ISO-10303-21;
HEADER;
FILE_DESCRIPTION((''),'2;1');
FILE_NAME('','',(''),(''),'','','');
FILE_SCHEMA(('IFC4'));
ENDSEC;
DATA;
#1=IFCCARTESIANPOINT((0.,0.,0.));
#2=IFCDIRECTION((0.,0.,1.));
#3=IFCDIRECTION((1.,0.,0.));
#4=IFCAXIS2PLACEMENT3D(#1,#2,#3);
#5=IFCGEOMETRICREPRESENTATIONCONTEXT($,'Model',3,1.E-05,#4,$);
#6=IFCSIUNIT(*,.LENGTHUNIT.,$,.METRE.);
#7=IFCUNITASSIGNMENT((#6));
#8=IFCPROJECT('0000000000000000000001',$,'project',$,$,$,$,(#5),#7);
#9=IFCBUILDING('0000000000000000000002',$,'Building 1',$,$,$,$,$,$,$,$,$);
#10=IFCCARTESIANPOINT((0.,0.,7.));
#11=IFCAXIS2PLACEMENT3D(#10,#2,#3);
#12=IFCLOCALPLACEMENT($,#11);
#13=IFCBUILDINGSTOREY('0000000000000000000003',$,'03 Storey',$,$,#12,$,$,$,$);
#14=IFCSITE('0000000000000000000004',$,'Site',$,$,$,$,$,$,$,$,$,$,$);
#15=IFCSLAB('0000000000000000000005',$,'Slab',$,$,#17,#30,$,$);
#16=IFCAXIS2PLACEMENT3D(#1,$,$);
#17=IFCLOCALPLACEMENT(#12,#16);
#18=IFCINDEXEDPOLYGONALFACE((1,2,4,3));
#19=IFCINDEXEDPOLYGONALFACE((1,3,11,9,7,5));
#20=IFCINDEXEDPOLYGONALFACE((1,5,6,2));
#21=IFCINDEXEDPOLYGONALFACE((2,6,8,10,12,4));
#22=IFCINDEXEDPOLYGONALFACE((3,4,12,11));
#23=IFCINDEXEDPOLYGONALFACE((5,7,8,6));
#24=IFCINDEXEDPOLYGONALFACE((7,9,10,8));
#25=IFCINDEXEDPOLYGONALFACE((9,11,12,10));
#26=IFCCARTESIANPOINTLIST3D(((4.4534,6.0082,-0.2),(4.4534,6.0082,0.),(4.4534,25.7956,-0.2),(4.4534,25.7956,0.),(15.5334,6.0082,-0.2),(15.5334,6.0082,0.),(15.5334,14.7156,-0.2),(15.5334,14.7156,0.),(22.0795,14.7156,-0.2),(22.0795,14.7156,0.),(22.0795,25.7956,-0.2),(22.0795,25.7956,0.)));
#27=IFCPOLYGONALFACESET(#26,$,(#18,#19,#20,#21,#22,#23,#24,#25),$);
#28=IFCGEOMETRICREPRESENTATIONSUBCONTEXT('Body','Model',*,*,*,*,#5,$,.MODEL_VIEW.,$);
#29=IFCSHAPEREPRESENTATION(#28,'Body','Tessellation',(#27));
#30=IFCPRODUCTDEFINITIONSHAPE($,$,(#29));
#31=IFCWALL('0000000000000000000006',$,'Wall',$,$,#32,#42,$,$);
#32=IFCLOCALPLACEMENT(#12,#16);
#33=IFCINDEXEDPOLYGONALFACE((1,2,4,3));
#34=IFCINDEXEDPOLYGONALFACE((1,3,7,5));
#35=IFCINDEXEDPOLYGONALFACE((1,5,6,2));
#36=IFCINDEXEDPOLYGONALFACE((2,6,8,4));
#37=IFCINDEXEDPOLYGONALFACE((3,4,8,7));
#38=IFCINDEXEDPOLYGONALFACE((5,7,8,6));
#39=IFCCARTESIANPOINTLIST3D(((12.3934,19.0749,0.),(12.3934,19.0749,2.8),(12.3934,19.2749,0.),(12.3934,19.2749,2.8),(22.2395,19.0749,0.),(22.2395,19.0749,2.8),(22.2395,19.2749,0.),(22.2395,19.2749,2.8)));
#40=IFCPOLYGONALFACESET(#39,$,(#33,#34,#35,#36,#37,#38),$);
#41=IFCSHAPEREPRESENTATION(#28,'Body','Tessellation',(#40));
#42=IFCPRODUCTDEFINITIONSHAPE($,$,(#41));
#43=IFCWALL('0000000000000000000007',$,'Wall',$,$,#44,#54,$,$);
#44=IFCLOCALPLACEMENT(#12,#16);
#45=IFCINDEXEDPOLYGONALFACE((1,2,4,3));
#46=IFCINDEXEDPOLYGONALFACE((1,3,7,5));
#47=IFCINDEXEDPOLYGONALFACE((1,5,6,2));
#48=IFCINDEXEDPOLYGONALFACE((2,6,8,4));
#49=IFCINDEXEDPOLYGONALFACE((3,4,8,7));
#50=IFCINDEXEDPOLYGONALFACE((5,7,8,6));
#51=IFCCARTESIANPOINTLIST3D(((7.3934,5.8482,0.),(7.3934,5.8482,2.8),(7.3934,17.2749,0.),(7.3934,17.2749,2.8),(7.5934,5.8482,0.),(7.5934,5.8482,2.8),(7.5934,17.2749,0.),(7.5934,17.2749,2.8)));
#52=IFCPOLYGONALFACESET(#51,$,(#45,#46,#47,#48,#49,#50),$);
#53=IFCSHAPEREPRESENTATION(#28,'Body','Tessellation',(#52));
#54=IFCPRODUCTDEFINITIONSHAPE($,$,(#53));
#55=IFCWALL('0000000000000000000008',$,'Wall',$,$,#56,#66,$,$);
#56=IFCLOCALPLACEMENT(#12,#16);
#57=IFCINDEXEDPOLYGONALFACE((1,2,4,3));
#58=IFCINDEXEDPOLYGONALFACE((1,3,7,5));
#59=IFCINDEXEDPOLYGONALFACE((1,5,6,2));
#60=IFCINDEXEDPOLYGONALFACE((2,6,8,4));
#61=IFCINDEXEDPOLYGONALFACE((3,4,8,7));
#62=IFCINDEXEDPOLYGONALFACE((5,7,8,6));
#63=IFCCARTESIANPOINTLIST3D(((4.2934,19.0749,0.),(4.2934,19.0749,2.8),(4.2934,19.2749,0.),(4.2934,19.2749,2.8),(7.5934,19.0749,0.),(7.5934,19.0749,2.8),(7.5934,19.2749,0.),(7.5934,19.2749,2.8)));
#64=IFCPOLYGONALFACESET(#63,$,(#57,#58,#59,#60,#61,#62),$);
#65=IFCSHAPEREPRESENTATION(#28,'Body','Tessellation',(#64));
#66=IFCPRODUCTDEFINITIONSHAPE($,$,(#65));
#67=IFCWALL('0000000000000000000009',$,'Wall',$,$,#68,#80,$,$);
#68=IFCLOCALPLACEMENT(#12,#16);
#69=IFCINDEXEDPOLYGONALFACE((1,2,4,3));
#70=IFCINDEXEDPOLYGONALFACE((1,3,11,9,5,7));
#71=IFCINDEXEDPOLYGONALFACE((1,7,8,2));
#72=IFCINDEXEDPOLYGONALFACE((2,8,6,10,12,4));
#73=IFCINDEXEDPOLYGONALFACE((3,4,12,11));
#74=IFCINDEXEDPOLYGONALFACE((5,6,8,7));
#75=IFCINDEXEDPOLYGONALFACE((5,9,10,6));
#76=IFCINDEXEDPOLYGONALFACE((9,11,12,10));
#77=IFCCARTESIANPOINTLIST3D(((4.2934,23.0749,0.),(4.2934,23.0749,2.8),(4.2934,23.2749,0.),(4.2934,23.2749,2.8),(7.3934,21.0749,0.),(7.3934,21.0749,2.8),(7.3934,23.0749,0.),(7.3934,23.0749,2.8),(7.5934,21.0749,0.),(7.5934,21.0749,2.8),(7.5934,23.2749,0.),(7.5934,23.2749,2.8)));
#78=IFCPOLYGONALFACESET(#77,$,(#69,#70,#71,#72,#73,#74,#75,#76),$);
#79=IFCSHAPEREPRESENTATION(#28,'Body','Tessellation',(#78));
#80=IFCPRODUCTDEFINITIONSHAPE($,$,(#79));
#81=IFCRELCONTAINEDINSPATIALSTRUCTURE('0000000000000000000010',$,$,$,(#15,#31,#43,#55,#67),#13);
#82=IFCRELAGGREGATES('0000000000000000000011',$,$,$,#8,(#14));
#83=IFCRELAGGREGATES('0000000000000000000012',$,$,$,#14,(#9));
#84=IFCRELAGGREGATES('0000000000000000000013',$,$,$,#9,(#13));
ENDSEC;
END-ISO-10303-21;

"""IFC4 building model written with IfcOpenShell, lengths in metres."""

from ifc_helpers import new_model, si_unit, frame, origin_with_axes, place, context, subcontext, project, spatial, line, indexed_curve, outline, extrude, element, save


model = new_model("IFC4")

# Units and contexts
model_context = context("Model", 3, precision=1e-05, world=origin_with_axes())
body_context = subcontext(model_context, "Body", "Model", "MODEL_VIEW")
ifc_project = project(units=[si_unit("LENGTHUNIT", "METRE")], contexts=[model_context])

# Site, building, storey
site = spatial("IfcSite", under=ifc_project, Name="Site")
building = spatial("IfcBuilding", under=site, Name="Building 1")
storey_placement = place(None, frame((0.0, 0.0, 7.0), z_axis=(0.0, 0.0, 1.0), x_axis=(1.0, 0.0, 0.0)))
storey = spatial("IfcBuildingStorey", under=building, at=storey_placement, Name="03 Storey")

# Slab
slab_placement = place(storey_placement, origin_with_axes())
element("IfcSlab", 1, at=slab_placement, inside=storey, Name="Slab", context=body_context, shape_type="SweptSolid", body=[
    extrude(outline(indexed_curve([(15.5334, 14.7156), (22.0795, 14.7156), (22.0795, 25.7956), (4.4534, 25.7956), (4.4534, 6.0082), (15.5334, 6.0082)], segments=[line(1, 2), line(2, 3), line(3, 4), line(4, 5), line(5, 6)])), origin_with_axes(), (0.0, 0.0, -1.0), 0.2),
])

# Walls
wall_1_placement = place(storey_placement, origin_with_axes())
element("IfcWall", 2, at=wall_1_placement, inside=storey, Name="Wall", context=body_context, shape_type="SweptSolid", body=[
    extrude(outline(indexed_curve([(22.2395, 19.2749), (12.3934, 19.2749), (12.3934, 19.0749), (22.2395, 19.0749)], segments=[line(1, 2), line(2, 3), line(3, 4)])), origin_with_axes(), (0.0, 0.0, 1.0), 2.8),
])
wall_2_placement = place(storey_placement, origin_with_axes())
element("IfcWall", 3, at=wall_2_placement, inside=storey, Name="Wall", context=body_context, shape_type="SweptSolid", body=[
    extrude(outline(indexed_curve([(7.5934, 17.2749), (7.3934, 17.2749), (7.3934, 5.8482), (7.5934, 5.8482)], segments=[line(1, 2), line(2, 3), line(3, 4)])), origin_with_axes(), (0.0, 0.0, 1.0), 2.8),
])
wall_3_placement = place(storey_placement, origin_with_axes())
element("IfcWall", 4, at=wall_3_placement, inside=storey, Name="Wall", context=body_context, shape_type="SweptSolid", body=[
    extrude(outline(indexed_curve([(7.5934, 19.2749), (4.2934, 19.2749), (4.2934, 19.0749), (7.5934, 19.0749)], segments=[line(1, 2), line(2, 3), line(3, 4)])), origin_with_axes(), (0.0, 0.0, 1.0), 2.8),
])
wall_4_placement = place(storey_placement, origin_with_axes())
element("IfcWall", 5, at=wall_4_placement, inside=storey, Name="Wall", context=body_context, shape_type="SweptSolid", body=[
    extrude(outline(indexed_curve([(7.5934, 23.2749), (4.2934, 23.2749), (4.2934, 23.0749), (7.3934, 23.0749), (7.3934, 21.0749), (7.5934, 21.0749)], segments=[line(1, 2), line(2, 3), line(3, 4), line(4, 5), line(5, 6)])), origin_with_axes(), (0.0, 0.0, 1.0), 2.8),
])

save(model, "model.ifc")
